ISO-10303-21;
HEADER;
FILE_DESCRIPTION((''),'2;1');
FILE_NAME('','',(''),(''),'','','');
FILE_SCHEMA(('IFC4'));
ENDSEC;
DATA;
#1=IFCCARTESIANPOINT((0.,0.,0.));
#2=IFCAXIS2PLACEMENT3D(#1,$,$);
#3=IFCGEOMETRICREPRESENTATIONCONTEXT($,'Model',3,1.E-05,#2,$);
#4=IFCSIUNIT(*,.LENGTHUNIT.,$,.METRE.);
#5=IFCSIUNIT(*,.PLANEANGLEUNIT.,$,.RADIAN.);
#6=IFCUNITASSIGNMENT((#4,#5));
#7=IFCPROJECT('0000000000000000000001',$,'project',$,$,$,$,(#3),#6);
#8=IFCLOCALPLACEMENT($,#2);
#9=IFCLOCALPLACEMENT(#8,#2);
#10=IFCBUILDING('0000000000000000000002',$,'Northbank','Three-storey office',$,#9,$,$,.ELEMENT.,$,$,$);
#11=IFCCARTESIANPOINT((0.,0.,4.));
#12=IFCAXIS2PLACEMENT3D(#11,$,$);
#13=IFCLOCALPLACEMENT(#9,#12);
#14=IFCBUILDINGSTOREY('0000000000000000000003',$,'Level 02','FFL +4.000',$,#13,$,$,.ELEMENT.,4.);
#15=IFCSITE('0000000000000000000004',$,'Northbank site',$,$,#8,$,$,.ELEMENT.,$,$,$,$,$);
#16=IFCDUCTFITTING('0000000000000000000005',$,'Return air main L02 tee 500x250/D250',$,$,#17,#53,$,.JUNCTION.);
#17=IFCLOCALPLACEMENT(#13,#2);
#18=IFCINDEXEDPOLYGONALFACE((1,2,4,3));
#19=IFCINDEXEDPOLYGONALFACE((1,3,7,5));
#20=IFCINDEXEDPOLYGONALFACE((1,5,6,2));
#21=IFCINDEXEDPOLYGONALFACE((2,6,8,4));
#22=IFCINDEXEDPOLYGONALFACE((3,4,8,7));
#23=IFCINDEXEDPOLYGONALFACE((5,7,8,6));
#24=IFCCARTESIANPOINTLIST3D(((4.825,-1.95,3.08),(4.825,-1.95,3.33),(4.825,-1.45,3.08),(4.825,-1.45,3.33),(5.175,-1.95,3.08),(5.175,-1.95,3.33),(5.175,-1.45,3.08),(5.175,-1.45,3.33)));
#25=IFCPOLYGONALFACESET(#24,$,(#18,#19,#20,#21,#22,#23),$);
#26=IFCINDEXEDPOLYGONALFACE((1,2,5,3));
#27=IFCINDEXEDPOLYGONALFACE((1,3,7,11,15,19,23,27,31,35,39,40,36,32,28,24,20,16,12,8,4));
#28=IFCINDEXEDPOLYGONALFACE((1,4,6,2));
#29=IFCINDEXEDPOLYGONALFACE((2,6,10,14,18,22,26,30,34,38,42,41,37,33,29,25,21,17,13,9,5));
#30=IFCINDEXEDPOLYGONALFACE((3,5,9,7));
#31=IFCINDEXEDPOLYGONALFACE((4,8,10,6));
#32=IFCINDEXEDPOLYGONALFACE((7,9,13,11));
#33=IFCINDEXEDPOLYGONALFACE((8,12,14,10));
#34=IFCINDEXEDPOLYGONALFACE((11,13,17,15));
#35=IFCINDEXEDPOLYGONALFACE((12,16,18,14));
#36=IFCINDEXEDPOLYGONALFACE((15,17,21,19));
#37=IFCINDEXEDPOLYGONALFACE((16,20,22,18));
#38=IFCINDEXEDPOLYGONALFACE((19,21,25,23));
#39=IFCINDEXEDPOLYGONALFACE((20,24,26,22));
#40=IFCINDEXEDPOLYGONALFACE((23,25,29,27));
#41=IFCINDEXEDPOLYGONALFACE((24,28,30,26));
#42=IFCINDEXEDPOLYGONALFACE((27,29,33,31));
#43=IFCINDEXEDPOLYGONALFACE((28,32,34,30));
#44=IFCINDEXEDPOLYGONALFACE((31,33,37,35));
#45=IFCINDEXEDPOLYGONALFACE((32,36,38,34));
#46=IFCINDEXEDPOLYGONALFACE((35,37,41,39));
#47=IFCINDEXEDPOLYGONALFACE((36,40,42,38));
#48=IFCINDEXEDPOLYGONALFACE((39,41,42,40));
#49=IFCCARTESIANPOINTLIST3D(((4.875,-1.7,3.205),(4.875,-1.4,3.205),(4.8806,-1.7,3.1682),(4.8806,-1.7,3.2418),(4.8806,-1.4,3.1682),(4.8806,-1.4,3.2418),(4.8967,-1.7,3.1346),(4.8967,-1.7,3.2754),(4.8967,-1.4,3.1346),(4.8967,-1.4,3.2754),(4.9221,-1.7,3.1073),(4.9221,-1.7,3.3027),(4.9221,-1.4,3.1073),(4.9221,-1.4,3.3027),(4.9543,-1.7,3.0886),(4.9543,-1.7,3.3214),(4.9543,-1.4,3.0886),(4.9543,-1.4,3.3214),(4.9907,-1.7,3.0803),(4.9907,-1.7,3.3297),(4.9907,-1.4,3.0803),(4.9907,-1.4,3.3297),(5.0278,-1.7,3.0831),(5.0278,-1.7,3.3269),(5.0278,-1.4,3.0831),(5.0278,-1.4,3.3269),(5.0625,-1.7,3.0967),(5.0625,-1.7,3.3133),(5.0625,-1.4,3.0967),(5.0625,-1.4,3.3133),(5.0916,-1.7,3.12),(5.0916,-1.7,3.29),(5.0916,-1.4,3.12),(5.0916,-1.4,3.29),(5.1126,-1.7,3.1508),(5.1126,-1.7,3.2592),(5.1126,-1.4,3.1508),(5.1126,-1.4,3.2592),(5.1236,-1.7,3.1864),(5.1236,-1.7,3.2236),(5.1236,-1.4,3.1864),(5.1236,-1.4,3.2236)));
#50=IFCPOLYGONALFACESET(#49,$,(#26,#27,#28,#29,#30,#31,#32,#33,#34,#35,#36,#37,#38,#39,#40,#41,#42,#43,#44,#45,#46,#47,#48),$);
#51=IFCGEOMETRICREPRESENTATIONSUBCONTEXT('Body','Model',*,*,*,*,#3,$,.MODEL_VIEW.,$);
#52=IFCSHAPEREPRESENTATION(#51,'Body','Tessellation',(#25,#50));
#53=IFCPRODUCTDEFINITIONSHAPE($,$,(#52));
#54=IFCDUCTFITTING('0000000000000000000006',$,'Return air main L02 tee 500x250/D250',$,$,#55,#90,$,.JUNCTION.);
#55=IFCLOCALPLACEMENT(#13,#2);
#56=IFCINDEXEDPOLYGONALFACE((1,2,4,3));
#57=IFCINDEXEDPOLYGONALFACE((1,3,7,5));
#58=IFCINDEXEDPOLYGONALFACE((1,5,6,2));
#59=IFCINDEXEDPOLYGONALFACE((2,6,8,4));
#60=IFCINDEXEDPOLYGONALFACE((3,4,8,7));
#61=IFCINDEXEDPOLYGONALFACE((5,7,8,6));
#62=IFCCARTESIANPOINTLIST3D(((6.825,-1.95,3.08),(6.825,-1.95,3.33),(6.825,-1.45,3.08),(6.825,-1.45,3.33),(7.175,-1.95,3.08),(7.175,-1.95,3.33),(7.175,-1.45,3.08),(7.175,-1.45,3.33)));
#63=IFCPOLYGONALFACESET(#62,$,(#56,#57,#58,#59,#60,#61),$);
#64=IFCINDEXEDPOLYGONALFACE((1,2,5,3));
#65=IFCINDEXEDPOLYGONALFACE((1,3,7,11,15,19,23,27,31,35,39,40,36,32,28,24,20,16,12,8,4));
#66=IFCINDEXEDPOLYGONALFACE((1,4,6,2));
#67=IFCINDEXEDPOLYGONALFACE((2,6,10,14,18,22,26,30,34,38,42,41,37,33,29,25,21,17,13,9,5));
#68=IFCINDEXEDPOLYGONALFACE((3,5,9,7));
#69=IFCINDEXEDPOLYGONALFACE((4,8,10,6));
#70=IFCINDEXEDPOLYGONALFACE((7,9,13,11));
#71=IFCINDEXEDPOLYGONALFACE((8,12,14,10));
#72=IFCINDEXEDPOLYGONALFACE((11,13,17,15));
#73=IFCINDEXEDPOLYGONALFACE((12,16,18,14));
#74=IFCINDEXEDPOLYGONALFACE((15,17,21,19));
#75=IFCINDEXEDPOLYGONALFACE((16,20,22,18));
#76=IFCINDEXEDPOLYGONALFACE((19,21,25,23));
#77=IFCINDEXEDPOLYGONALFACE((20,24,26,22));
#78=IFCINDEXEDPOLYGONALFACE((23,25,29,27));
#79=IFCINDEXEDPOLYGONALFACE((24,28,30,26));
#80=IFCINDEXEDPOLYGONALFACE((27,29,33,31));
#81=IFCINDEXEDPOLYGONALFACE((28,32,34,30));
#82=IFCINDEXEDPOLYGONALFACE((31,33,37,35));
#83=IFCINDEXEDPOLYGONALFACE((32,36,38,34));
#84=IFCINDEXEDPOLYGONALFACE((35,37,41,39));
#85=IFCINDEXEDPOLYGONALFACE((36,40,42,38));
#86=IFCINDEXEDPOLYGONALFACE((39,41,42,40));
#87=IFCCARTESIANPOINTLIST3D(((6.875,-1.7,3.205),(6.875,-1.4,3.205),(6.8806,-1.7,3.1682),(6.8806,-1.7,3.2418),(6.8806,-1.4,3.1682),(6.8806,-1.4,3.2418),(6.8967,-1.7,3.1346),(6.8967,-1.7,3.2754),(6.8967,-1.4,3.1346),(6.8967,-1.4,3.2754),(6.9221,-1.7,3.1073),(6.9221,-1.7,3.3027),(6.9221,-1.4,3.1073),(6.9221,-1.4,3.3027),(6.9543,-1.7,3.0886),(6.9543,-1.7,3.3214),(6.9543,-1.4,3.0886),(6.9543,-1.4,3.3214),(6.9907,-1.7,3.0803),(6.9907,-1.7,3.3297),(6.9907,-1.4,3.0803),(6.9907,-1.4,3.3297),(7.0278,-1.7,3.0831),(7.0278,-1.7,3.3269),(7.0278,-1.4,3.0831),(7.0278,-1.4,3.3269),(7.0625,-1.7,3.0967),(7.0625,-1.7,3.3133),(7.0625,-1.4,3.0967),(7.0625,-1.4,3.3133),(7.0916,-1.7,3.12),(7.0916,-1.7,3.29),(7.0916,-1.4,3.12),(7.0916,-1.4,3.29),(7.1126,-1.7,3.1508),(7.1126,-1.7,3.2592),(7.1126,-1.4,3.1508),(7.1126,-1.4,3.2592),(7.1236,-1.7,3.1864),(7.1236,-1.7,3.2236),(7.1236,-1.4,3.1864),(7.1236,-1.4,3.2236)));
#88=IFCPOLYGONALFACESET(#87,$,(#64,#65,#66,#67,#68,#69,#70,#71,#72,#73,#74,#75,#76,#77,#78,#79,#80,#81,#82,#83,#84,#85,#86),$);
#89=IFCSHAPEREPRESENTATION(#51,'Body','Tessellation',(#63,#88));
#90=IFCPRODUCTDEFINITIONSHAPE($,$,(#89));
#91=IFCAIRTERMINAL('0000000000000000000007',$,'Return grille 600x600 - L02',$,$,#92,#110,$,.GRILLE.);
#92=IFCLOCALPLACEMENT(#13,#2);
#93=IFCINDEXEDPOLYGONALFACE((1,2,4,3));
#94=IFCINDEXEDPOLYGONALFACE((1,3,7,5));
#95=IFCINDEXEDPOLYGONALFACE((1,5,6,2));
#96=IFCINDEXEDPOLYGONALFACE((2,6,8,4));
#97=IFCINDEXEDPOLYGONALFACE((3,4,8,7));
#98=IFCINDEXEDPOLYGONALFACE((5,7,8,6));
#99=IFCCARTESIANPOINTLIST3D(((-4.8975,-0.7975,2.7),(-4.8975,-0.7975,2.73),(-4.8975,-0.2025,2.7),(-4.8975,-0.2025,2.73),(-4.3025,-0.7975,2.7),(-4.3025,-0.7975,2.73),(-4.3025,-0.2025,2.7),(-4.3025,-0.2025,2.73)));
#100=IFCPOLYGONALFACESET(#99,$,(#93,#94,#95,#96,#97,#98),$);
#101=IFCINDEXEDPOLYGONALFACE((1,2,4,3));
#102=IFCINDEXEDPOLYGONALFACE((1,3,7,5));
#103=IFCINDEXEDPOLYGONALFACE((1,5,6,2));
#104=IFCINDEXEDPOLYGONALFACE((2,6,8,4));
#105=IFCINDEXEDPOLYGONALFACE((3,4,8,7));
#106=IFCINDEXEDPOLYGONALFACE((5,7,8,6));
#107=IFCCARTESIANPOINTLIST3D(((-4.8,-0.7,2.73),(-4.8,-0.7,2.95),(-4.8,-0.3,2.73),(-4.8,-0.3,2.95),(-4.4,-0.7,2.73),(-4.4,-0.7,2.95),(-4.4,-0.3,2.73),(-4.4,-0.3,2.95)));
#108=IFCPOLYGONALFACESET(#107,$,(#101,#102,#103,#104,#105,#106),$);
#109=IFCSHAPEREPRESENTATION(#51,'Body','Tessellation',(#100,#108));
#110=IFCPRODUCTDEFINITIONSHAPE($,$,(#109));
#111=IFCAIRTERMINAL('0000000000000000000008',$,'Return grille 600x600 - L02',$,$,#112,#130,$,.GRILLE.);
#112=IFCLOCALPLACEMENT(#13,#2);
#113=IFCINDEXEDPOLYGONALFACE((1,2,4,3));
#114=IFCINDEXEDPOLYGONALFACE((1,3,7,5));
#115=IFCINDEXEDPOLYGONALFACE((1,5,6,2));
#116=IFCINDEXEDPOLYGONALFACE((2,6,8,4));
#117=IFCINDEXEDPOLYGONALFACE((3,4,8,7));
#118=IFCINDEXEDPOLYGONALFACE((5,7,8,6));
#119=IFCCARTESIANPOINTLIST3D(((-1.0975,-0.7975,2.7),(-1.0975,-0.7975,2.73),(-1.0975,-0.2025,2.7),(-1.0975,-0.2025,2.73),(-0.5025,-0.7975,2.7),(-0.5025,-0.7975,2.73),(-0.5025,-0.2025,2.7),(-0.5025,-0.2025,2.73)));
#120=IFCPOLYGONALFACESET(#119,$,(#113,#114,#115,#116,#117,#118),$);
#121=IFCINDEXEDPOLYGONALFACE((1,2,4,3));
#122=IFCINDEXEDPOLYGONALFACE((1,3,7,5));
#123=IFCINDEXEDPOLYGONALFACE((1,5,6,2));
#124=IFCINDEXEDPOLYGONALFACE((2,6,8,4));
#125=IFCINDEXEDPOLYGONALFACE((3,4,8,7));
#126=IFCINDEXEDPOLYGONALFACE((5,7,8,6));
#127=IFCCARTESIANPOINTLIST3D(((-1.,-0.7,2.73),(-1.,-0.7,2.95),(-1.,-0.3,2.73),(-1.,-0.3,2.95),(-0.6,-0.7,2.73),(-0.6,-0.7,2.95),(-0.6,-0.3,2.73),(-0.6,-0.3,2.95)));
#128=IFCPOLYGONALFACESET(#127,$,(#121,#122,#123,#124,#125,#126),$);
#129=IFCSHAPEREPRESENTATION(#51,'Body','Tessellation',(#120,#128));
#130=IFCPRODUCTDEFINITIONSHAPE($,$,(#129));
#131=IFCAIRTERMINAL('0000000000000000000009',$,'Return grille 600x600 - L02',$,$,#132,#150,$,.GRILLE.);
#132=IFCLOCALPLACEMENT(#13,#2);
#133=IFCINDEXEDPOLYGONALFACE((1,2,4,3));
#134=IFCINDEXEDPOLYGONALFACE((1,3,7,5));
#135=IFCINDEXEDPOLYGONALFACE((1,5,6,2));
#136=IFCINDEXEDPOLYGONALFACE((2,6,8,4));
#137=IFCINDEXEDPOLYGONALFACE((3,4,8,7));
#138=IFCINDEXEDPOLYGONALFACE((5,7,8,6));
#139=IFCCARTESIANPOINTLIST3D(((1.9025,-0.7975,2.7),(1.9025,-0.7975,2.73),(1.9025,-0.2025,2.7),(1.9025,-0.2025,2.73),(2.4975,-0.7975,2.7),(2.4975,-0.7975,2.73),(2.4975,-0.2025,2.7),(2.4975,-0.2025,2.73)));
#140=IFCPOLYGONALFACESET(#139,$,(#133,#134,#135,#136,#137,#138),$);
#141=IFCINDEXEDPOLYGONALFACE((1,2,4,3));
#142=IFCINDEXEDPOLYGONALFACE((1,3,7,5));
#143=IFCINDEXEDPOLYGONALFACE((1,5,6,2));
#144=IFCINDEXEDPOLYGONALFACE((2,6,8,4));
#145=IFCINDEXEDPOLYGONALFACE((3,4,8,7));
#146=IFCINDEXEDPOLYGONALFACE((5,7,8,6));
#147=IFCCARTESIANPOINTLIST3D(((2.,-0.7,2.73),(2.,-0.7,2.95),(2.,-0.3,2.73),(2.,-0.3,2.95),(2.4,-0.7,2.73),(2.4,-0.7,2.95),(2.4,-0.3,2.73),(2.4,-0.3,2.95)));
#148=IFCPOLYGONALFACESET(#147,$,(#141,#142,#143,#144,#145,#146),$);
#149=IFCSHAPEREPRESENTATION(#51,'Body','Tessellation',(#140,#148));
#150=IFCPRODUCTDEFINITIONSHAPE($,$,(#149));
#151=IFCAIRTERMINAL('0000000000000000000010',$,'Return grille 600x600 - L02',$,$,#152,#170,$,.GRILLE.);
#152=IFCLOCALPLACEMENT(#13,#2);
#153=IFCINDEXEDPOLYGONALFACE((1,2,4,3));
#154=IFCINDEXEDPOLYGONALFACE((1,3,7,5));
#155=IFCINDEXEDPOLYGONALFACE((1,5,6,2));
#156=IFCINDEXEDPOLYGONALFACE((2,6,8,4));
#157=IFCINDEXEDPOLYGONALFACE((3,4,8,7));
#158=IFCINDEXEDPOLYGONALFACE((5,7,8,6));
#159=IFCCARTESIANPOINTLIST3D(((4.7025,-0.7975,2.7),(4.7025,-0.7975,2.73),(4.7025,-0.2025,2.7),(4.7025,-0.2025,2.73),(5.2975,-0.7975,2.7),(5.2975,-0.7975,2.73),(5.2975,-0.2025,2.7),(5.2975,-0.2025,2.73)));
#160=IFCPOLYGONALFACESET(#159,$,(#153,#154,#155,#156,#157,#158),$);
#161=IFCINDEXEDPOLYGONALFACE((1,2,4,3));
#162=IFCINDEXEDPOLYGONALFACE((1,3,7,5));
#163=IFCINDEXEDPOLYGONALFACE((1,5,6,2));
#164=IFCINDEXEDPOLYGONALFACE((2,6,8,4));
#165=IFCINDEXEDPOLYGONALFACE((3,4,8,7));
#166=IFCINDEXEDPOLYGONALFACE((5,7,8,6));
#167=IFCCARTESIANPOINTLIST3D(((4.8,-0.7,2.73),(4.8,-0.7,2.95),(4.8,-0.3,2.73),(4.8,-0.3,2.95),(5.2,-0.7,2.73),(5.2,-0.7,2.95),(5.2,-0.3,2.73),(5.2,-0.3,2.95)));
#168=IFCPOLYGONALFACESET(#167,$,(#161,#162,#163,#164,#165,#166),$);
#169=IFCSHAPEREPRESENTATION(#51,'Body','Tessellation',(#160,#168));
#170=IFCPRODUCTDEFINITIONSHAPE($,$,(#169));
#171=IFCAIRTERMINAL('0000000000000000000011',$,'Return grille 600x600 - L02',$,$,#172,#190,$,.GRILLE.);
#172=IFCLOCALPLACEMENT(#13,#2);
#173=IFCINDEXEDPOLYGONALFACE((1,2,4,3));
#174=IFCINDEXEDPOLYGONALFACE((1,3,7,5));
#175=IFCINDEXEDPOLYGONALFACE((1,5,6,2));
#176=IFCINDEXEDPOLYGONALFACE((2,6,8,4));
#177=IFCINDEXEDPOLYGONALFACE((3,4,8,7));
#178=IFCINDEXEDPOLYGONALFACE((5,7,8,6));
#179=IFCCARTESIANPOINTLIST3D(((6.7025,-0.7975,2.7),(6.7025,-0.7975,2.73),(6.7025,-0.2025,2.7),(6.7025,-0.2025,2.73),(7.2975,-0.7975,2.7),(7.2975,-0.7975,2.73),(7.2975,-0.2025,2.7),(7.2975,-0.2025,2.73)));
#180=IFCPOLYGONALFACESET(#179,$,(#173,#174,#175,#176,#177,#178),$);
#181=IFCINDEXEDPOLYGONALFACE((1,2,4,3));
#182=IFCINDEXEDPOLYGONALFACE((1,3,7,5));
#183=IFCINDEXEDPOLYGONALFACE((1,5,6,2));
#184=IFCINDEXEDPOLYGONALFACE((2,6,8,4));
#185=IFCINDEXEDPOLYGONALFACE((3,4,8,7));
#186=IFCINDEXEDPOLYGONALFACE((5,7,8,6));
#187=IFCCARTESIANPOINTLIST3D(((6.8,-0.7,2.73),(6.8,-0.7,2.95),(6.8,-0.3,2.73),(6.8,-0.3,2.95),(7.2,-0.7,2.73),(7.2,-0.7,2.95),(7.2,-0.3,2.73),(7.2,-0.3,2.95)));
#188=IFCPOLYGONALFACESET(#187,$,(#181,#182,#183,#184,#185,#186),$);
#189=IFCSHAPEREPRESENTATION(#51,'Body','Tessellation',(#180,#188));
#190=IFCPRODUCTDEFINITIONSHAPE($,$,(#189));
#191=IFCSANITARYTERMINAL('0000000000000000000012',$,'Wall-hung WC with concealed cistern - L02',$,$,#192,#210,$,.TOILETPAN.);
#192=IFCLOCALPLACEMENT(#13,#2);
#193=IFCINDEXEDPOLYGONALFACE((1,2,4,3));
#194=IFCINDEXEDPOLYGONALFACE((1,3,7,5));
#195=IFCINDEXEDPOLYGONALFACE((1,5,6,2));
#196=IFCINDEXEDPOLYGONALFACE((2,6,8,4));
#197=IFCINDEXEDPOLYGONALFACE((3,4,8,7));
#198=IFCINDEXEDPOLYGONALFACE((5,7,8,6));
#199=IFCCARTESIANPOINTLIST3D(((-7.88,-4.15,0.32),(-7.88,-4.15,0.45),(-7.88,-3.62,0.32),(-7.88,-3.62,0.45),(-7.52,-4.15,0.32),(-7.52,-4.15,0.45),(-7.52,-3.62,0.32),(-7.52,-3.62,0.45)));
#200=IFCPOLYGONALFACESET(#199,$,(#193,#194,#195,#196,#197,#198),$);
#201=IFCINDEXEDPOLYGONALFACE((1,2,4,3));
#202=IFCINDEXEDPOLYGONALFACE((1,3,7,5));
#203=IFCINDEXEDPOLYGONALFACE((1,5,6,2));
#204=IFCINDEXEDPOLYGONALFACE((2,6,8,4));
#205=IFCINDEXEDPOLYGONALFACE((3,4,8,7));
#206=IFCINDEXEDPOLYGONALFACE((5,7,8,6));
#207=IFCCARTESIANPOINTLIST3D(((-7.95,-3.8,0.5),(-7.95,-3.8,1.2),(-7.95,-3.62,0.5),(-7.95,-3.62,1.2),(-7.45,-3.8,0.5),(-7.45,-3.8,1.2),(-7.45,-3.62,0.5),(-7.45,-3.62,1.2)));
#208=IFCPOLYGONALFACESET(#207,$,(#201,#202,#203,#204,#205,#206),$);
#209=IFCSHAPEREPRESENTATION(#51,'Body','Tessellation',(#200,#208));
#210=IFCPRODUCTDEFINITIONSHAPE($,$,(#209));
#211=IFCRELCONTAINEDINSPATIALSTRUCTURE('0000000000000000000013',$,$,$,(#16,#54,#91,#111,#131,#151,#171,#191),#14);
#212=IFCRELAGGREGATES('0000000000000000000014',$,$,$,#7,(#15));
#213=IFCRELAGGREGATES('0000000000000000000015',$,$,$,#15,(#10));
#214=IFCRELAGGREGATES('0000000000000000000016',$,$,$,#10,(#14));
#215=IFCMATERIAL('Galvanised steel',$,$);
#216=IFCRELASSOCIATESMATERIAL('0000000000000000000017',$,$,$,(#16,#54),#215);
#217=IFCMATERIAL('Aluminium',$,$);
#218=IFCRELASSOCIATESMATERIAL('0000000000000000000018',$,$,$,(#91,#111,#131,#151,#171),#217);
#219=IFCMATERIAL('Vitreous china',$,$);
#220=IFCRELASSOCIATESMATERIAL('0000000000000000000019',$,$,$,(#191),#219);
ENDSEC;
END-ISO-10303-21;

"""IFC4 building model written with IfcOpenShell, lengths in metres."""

from ifc_helpers import new_model, si_unit, frame, origin, place, context, subcontext, project, spatial, rectangle, circle, extrude, material, element, save


model = new_model("IFC4")

# Units and contexts
model_context = context("Model", 3, precision=1e-05, world=origin())
body_context = subcontext(model_context, "Body", "Model", "MODEL_VIEW")
ifc_project = project(units=[si_unit("LENGTHUNIT", "METRE"), si_unit("PLANEANGLEUNIT", "RADIAN")], contexts=[model_context])

# Site, building, storey
site_placement = place(None, origin())
site = spatial("IfcSite", under=ifc_project, at=site_placement, Name="Northbank site", CompositionType="ELEMENT")
building_placement = place(site_placement, origin())
building = spatial("IfcBuilding", under=site, at=building_placement, Name="Northbank", Description="Three-storey office", CompositionType="ELEMENT")
storey_placement = place(building_placement, frame((0.0, 0.0, 4.0)))
storey = spatial("IfcBuildingStorey", under=building, at=storey_placement, Name="Level 02", Description="FFL +4.000", CompositionType="ELEMENT", Elevation=4.0)

# Duct fitting
ifc_material_1 = material(Name="Galvanised steel")
duct_fitting_1_placement = place(storey_placement, frame((0.0, 0.0, -4.0)))
element("IfcDuctFitting", 1, at=duct_fitting_1_placement, inside=storey, material=ifc_material_1, Name="Return air main L02 tee 500x250/D250", PredefinedType="JUNCTION", context=body_context, shape_type="SweptSolid", body=[
    extrude(rectangle(XDim=0.5, YDim=0.25), frame((4.825, -1.7, 7.205), z_axis=(1.0, 0.0, 0.0), x_axis=(0.0, 1.0, 0.0)), (0.0, 0.0, 1.0), 0.35),
    extrude(circle(Radius=0.125), frame((5.0, -1.7, 7.205), z_axis=(0.0, 1.0, 0.0), x_axis=(-1.0, 0.0, 0.0)), (0.0, 0.0, 1.0), 0.3),
])

# Duct fitting
duct_fitting_2_placement = place(storey_placement, frame((0.0, 0.0, -4.0)))
element("IfcDuctFitting", 2, at=duct_fitting_2_placement, inside=storey, material=ifc_material_1, Name="Return air main L02 tee 500x250/D250", PredefinedType="JUNCTION", context=body_context, shape_type="SweptSolid", body=[
    extrude(rectangle(XDim=0.5, YDim=0.25), frame((6.825, -1.7, 7.205), z_axis=(1.0, 0.0, 0.0), x_axis=(0.0, 1.0, 0.0)), (0.0, 0.0, 1.0), 0.35),
    extrude(circle(Radius=0.125), frame((7.0, -1.7, 7.205), z_axis=(0.0, 1.0, 0.0), x_axis=(-1.0, 0.0, 0.0)), (0.0, 0.0, 1.0), 0.3),
])

# Air terminal
ifc_material_2 = material(Name="Aluminium")
air_terminal_1_placement = place(storey_placement, frame((0.0, 0.0, -4.0)))
element("IfcAirTerminal", 3, at=air_terminal_1_placement, inside=storey, material=ifc_material_2, Name="Return grille 600x600 - L02", PredefinedType="GRILLE", context=body_context, shape_type="SweptSolid", body=[
    extrude(rectangle(XDim=0.595, YDim=0.595), frame((-4.6, -0.5, 6.7)), (0.0, 0.0, 1.0), 0.03),
    extrude(rectangle(XDim=0.4, YDim=0.4), frame((-4.6, -0.5, 6.73)), (0.0, 0.0, 1.0), 0.22),
])

# Air terminal
air_terminal_2_placement = place(storey_placement, frame((0.0, 0.0, -4.0)))
element("IfcAirTerminal", 4, at=air_terminal_2_placement, inside=storey, material=ifc_material_2, Name="Return grille 600x600 - L02", PredefinedType="GRILLE", context=body_context, shape_type="SweptSolid", body=[
    extrude(rectangle(XDim=0.595, YDim=0.595), frame((-0.8, -0.5, 6.7)), (0.0, 0.0, 1.0), 0.03),
    extrude(rectangle(XDim=0.4, YDim=0.4), frame((-0.8, -0.5, 6.73)), (0.0, 0.0, 1.0), 0.22),
])

# Air terminal
air_terminal_3_placement = place(storey_placement, frame((0.0, 0.0, -4.0)))
element("IfcAirTerminal", 5, at=air_terminal_3_placement, inside=storey, material=ifc_material_2, Name="Return grille 600x600 - L02", PredefinedType="GRILLE", context=body_context, shape_type="SweptSolid", body=[
    extrude(rectangle(XDim=0.595, YDim=0.595), frame((2.2, -0.5, 6.7)), (0.0, 0.0, 1.0), 0.03),
    extrude(rectangle(XDim=0.4, YDim=0.4), frame((2.2, -0.5, 6.73)), (0.0, 0.0, 1.0), 0.22),
])

# Air terminal
air_terminal_4_placement = place(storey_placement, frame((0.0, 0.0, -4.0)))
element("IfcAirTerminal", 6, at=air_terminal_4_placement, inside=storey, material=ifc_material_2, Name="Return grille 600x600 - L02", PredefinedType="GRILLE", context=body_context, shape_type="SweptSolid", body=[
    extrude(rectangle(XDim=0.595, YDim=0.595), frame((5.0, -0.5, 6.7)), (0.0, 0.0, 1.0), 0.03),
    extrude(rectangle(XDim=0.4, YDim=0.4), frame((5.0, -0.5, 6.73)), (0.0, 0.0, 1.0), 0.22),
])

# Air terminal
air_terminal_5_placement = place(storey_placement, frame((0.0, 0.0, -4.0)))
element("IfcAirTerminal", 7, at=air_terminal_5_placement, inside=storey, material=ifc_material_2, Name="Return grille 600x600 - L02", PredefinedType="GRILLE", context=body_context, shape_type="SweptSolid", body=[
    extrude(rectangle(XDim=0.595, YDim=0.595), frame((7.0, -0.5, 6.7)), (0.0, 0.0, 1.0), 0.03),
    extrude(rectangle(XDim=0.4, YDim=0.4), frame((7.0, -0.5, 6.73)), (0.0, 0.0, 1.0), 0.22),
])

# Sanitary terminal
ifc_material_3 = material(Name="Vitreous china")
sanitary_terminal_1_placement = place(storey_placement, frame((0.0, 0.0, -4.0)))
element("IfcSanitaryTerminal", 8, at=sanitary_terminal_1_placement, inside=storey, material=ifc_material_3, Name="Wall-hung WC with concealed cistern - L02", PredefinedType="TOILETPAN", context=body_context, shape_type="SweptSolid", body=[
    extrude(rectangle(XDim=0.36, YDim=0.53), frame((-7.7, -3.885, 4.32)), (0.0, 0.0, 1.0), 0.13),
    extrude(rectangle(XDim=0.5, YDim=0.18), frame((-7.7, -3.71, 4.5)), (0.0, 0.0, 1.0), 0.7),
])

save(model, "model.ifc")
